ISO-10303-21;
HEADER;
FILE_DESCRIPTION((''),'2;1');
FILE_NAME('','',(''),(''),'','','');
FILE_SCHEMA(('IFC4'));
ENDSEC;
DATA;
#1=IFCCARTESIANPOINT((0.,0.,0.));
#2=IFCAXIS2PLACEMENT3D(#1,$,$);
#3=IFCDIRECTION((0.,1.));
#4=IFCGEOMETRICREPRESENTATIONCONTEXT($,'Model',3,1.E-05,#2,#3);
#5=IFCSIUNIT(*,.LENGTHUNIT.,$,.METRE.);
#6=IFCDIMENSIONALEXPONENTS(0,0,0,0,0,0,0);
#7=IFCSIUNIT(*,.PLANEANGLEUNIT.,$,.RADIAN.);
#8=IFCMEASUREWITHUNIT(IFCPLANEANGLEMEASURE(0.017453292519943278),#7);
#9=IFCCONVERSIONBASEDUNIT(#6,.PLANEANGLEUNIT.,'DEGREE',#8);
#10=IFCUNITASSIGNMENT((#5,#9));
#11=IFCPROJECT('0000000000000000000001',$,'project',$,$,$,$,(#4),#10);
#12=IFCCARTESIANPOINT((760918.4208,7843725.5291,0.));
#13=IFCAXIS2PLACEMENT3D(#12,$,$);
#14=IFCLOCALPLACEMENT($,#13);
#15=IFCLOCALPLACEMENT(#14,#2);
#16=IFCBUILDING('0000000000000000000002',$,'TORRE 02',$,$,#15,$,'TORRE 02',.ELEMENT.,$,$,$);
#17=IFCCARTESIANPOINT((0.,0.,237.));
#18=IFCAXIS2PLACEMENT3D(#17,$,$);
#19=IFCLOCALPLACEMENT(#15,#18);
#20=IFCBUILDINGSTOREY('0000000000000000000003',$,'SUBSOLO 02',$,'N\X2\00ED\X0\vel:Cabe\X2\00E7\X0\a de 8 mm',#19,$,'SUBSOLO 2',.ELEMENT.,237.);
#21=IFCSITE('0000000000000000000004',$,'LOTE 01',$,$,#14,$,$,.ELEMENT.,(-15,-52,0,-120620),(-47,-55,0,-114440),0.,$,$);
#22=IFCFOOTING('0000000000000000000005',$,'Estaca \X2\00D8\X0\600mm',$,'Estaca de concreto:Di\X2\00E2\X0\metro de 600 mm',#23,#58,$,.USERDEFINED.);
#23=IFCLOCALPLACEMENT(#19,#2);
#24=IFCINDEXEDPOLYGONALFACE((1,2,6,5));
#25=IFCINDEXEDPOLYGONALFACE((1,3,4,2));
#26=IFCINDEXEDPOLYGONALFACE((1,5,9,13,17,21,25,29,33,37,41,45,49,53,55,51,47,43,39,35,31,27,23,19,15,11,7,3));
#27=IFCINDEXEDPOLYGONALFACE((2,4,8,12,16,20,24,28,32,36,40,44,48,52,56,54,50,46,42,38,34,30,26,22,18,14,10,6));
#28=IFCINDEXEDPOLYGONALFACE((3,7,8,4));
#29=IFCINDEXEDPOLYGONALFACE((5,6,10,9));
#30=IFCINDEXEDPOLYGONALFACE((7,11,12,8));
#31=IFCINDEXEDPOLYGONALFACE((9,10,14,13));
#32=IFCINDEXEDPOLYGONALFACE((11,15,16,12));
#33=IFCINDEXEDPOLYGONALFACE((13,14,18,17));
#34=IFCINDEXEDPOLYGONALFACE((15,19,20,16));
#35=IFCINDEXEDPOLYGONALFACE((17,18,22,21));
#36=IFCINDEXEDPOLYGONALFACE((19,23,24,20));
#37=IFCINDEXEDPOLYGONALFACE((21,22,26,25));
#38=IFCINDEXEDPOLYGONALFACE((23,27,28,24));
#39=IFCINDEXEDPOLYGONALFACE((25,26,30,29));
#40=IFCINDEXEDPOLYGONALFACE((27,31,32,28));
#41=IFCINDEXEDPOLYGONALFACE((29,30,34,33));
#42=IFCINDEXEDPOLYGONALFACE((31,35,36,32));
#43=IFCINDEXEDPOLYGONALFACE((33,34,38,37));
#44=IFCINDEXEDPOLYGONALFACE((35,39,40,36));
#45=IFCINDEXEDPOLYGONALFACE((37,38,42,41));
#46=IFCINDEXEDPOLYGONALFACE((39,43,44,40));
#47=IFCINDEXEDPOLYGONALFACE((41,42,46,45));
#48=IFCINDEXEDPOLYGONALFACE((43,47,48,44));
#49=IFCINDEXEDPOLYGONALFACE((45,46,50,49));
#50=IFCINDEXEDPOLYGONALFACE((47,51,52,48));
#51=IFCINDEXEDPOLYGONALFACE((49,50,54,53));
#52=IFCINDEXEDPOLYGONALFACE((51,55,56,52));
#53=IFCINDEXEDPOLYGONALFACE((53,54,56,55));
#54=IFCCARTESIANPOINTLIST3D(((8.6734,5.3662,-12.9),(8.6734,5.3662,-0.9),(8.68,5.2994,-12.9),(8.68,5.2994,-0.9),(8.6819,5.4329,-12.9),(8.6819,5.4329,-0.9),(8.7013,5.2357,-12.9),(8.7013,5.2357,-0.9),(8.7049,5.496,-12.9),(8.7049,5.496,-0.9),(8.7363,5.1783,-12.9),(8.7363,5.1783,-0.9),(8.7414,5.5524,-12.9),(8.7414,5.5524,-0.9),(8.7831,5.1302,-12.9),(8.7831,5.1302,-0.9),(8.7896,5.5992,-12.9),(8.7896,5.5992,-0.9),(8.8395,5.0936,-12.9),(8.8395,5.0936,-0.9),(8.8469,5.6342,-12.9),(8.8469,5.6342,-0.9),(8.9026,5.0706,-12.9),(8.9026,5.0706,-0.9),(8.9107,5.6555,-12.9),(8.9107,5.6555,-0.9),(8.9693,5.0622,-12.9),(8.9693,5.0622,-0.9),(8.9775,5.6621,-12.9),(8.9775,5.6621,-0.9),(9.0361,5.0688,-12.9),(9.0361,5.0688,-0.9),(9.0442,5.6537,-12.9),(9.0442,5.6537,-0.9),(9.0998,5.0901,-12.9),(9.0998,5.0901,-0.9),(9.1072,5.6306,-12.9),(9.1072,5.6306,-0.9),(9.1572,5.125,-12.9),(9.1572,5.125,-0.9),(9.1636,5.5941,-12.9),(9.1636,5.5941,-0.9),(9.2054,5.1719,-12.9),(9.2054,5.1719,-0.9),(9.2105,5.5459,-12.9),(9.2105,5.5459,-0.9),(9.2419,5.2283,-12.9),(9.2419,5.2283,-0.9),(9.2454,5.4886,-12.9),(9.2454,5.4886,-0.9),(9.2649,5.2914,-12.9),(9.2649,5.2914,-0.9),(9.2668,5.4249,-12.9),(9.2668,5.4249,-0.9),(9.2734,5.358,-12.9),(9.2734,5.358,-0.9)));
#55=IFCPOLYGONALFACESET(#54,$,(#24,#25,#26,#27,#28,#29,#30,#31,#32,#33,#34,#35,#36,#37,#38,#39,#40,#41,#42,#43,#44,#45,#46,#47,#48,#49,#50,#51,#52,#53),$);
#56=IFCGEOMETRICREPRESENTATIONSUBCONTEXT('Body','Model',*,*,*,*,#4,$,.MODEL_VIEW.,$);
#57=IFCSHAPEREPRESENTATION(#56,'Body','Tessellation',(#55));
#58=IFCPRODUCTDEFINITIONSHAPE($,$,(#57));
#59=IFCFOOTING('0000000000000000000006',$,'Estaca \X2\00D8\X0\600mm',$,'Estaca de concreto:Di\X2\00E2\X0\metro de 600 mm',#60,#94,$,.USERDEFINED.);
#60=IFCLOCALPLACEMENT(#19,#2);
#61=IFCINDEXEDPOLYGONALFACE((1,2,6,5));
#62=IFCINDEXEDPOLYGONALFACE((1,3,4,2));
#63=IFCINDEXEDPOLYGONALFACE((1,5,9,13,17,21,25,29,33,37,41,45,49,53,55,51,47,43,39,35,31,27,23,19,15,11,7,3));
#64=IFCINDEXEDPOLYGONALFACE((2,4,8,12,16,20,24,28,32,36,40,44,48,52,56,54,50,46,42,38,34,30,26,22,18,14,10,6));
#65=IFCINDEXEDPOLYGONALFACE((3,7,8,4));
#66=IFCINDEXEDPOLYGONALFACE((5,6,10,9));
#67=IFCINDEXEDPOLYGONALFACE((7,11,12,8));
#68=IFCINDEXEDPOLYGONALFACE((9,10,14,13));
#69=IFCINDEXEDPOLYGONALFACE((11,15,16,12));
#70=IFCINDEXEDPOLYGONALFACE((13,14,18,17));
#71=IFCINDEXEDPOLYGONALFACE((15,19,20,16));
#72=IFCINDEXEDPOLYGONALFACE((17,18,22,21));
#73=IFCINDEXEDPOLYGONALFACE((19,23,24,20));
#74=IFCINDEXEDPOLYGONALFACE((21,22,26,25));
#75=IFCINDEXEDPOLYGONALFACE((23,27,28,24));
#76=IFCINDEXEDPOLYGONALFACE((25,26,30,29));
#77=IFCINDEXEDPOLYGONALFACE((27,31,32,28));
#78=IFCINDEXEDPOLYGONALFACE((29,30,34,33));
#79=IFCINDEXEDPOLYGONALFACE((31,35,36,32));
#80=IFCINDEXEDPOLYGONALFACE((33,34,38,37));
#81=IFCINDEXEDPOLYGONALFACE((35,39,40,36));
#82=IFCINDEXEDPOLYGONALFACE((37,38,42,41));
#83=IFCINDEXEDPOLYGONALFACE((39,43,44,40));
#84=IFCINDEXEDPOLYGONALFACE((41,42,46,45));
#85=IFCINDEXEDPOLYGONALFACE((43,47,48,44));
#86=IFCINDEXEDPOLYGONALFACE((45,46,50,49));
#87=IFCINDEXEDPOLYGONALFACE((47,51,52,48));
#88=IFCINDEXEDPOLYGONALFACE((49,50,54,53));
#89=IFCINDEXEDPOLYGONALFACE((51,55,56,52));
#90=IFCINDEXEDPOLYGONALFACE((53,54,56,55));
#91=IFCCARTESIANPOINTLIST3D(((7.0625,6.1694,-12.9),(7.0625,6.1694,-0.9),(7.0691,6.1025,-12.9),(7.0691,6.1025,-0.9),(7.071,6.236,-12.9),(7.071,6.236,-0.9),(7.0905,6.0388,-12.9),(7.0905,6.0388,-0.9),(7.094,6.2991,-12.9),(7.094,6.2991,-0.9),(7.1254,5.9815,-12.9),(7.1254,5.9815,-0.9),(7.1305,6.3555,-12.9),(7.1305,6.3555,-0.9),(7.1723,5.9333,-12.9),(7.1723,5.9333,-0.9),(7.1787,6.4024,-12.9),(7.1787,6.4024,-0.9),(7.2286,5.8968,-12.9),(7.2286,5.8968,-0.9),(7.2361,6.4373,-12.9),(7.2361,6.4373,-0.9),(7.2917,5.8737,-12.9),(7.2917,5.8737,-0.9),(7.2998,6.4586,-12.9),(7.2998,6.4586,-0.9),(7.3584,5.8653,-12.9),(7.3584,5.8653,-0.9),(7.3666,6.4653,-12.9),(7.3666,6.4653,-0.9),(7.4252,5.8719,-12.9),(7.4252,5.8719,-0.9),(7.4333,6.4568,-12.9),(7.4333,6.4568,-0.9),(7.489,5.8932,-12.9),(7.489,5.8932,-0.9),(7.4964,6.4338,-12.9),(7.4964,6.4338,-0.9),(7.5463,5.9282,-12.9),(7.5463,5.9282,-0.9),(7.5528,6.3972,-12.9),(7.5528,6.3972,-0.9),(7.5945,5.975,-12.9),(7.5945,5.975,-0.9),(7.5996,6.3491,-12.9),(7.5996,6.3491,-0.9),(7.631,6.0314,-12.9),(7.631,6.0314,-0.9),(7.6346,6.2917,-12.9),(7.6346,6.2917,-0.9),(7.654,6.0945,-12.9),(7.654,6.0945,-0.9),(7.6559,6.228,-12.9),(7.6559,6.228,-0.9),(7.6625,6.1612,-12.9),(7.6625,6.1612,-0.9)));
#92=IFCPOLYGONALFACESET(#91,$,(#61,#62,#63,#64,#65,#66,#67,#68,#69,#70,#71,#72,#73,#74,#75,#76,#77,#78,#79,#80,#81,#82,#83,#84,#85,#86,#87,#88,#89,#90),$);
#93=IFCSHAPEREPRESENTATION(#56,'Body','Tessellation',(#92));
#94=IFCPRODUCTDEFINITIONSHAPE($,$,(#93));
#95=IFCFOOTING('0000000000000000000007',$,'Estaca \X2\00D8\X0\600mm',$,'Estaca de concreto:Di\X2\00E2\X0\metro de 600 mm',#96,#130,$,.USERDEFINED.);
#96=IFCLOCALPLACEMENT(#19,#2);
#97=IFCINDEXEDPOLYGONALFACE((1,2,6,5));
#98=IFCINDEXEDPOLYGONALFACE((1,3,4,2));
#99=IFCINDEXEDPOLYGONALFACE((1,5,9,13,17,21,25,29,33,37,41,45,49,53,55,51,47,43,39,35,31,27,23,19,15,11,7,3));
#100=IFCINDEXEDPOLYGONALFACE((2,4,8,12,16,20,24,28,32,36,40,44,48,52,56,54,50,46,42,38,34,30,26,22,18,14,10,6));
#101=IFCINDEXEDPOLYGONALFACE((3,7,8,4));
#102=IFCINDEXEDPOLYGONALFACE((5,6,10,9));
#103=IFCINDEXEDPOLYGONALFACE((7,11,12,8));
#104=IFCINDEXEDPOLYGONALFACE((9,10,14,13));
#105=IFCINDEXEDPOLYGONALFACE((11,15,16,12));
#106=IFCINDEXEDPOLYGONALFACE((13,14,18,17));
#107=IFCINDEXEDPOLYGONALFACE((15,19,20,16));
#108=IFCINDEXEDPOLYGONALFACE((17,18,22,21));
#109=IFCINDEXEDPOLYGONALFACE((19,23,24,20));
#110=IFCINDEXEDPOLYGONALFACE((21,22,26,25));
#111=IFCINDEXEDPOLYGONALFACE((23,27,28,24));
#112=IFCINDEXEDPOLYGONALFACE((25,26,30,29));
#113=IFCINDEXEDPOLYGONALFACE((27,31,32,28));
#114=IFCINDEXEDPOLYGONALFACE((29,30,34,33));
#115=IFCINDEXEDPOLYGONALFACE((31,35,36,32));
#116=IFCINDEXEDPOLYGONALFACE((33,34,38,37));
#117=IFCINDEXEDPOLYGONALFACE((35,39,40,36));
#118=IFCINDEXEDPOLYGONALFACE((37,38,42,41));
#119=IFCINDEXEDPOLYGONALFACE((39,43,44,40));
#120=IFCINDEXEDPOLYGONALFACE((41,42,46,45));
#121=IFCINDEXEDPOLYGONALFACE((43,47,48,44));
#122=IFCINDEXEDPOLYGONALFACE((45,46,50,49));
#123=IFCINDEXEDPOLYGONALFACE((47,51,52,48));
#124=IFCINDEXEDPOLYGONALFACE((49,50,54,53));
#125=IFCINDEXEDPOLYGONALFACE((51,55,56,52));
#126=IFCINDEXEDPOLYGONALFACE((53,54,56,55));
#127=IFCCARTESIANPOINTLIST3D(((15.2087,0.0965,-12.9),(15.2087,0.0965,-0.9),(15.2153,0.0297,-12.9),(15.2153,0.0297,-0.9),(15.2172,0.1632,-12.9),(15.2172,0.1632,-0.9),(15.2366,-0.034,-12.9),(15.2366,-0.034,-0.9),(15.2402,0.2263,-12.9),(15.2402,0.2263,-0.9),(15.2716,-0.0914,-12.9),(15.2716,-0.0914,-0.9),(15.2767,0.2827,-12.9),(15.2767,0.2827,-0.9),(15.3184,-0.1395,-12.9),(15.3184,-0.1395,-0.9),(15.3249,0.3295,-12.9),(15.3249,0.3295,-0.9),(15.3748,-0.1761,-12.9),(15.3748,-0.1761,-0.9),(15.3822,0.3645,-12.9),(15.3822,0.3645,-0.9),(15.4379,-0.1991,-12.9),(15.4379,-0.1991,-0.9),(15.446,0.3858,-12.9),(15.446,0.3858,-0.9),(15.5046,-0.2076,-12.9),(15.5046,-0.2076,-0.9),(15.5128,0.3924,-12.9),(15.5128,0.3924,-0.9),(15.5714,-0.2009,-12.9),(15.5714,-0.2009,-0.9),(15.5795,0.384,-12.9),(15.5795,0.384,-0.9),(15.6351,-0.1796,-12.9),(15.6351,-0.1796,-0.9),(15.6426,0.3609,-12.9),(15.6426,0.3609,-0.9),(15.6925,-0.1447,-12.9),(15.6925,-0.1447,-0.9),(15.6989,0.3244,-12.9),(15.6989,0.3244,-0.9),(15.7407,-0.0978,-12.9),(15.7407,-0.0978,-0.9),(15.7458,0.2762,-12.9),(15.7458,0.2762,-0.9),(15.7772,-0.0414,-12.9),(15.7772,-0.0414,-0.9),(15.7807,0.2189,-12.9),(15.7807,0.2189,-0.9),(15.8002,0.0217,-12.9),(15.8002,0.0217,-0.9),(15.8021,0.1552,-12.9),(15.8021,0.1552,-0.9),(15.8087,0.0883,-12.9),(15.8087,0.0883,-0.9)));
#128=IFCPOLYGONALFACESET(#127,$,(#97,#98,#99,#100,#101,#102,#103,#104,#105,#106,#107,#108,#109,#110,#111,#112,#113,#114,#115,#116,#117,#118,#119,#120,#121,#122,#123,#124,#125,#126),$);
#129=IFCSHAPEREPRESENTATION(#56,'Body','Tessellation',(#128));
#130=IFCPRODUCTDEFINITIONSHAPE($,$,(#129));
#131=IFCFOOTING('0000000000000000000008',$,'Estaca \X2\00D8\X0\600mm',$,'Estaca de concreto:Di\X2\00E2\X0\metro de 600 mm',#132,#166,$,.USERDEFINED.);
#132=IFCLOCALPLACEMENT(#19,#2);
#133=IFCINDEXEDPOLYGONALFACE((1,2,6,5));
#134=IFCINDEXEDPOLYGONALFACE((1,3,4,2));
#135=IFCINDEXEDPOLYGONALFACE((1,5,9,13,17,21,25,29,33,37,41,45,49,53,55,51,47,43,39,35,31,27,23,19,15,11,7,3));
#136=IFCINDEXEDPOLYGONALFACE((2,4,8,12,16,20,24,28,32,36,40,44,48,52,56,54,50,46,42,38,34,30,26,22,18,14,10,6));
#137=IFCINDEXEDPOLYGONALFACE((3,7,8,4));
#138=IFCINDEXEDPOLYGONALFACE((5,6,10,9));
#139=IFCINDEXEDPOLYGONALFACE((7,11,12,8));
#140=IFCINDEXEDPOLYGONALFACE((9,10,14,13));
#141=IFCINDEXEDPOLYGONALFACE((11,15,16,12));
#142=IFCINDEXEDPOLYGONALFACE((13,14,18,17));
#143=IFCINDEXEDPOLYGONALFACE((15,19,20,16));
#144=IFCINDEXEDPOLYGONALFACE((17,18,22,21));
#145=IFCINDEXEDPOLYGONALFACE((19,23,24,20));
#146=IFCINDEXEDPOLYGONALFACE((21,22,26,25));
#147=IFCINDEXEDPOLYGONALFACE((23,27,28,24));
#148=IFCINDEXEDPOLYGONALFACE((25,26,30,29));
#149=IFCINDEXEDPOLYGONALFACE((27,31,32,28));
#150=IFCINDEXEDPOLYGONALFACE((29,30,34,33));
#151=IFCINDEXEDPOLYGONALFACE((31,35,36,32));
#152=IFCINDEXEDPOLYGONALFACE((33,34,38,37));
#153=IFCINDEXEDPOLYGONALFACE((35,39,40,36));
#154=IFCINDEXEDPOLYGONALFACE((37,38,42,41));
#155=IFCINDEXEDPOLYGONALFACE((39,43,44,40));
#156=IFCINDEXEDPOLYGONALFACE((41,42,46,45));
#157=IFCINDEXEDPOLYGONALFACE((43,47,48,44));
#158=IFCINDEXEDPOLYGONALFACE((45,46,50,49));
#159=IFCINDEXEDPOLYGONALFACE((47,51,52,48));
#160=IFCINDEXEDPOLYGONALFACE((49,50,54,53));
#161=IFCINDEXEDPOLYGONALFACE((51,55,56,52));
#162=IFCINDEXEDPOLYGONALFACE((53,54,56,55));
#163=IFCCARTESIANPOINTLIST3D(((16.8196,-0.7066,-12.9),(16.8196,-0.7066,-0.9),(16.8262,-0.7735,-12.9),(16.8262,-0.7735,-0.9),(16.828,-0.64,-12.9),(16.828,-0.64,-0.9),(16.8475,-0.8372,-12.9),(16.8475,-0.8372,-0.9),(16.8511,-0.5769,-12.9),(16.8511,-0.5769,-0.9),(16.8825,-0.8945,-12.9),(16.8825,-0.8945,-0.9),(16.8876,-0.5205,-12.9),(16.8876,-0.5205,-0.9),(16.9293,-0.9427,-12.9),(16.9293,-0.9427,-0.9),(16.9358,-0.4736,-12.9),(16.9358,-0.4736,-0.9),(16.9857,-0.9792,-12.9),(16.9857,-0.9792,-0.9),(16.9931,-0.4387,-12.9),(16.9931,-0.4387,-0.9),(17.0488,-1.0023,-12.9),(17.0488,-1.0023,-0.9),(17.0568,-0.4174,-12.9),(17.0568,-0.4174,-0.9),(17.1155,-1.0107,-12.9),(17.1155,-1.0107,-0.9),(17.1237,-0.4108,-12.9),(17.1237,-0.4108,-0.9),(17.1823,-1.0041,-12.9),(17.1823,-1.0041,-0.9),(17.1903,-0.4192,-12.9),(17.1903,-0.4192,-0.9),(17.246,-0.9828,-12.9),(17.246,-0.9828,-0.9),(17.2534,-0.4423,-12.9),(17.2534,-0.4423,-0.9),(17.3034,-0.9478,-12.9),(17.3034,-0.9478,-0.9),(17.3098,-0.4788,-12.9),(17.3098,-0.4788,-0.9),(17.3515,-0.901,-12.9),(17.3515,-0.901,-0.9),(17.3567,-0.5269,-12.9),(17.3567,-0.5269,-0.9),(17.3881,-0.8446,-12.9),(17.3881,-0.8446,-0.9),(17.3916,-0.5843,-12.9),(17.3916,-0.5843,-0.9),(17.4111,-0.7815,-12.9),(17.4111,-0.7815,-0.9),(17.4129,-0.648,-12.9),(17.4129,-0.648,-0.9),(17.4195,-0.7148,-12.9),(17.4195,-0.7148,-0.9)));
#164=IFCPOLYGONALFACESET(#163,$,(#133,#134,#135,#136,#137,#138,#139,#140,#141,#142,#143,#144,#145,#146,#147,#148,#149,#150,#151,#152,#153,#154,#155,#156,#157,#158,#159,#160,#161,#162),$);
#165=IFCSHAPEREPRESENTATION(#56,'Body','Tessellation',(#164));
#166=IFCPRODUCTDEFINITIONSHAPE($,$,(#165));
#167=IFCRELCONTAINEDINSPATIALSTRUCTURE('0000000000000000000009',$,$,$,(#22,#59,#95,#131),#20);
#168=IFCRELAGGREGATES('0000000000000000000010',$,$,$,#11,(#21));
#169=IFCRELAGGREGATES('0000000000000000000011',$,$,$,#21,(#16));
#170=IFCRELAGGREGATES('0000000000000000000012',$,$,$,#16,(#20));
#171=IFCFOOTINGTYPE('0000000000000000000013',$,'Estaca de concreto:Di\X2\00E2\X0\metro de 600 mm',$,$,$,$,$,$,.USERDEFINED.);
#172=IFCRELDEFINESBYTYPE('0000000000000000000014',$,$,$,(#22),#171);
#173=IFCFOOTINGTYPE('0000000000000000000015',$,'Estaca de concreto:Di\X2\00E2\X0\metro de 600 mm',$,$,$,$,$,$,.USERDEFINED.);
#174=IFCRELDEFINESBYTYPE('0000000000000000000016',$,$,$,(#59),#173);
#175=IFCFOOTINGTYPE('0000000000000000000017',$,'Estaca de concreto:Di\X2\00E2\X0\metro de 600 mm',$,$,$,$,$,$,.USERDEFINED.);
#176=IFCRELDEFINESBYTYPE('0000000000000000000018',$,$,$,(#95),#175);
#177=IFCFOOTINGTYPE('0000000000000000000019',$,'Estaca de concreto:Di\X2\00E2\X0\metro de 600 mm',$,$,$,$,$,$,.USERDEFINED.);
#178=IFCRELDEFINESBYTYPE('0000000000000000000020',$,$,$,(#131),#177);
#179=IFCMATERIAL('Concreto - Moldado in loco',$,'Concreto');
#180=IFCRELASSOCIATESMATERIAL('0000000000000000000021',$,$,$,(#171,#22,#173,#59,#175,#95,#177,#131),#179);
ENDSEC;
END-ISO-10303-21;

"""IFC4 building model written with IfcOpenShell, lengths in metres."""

from ifc_helpers import new_model, entity, si_unit, converted_unit, direction, frame, origin, place, context, subcontext, project, spatial, arc, indexed_curve, outline, extrude, source, transform, mapped, material, type_object, type_shapes, element, save


model = new_model("IFC4")

# Units and contexts
model_context = context("Model", 3, precision=1e-05, world=origin(), true_north=direction((0.0, 1.0)))
body_context = subcontext(model_context, "Body", "Model", "MODEL_VIEW")
ifc_project = project(units=[si_unit("LENGTHUNIT", "METRE"), converted_unit("PLANEANGLEUNIT", "DEGREE", entity("IfcPlaneAngleMeasure", 0.017453292519943278), si_unit("PLANEANGLEUNIT", "RADIAN"), dimensions=[0, 0, 0, 0, 0, 0, 0])], contexts=[model_context])

# Site, building, storey
site_placement = place(None, frame((760918.4208, 7843725.5291, 0.0)))
site = spatial("IfcSite", under=ifc_project, at=site_placement, Name="LOTE 01", CompositionType="ELEMENT", RefLatitude=(-15, -52, 0, -120620), RefLongitude=(-47, -55, 0, -114440), RefElevation=0.0)
building_placement = place(site_placement, origin())
building = spatial("IfcBuilding", under=site, at=building_placement, Name="TORRE 02", LongName="TORRE 02", CompositionType="ELEMENT")
storey_placement = place(building_placement, frame((0.0, 0.0, 237.0)))
storey = spatial("IfcBuildingStorey", under=building, at=storey_placement, Name="SUBSOLO 02", ObjectType="Nível:Cabeça de 8 mm", LongName="SUBSOLO 2", CompositionType="ELEMENT", Elevation=237.0)

# Footings
ifc_material = material(Name="Concreto - Moldado in loco", Category="Concreto")
placement = place(building_placement, frame((0.0, 0.0, 237.0)))
footing_type_1 = type_object("IfcFootingType", Name="Estaca de concreto:Diâmetro de 600 mm", PredefinedType="USERDEFINED", material=ifc_material)
shared_shape_1 = source(origin(), body_context, "Body", "SweptSolid", [
    extrude(outline(indexed_curve([(-0.3, 0.0), (0.0, -0.3), (0.3, 0.0), (0.0, 0.3)], segments=[arc(1, 2, 3), arc(3, 4, 1)], self_intersect=False)), frame((8.9734, 5.3621, -12.0), z_axis=(0.0, 0.0, 1.0), x_axis=(0.894934, -0.446198, 0.0)), (0.0, 0.0, 1.0), 12.0),
])
type_shapes(footing_type_1, [shared_shape_1])
footing_1_placement = place(placement, frame((0.0, 0.0, -0.9)))
element("IfcFooting", 1, at=footing_1_placement, inside=storey, type_object=footing_type_1, material=ifc_material, Name="Estaca Ø600mm", ObjectType="Estaca de concreto:Diâmetro de 600 mm", PredefinedType="USERDEFINED", context=body_context, shape_type="MappedRepresentation", body=[
    mapped(shared_shape_1, transform((0.0, 0.0, 0.0), scale=1.0)),
])
footing_type_2 = type_object("IfcFootingType", Name="Estaca de concreto:Diâmetro de 600 mm", PredefinedType="USERDEFINED", material=ifc_material)
shared_shape_2 = source(origin(), body_context, "Body", "SweptSolid", [
    extrude(outline(indexed_curve([(-0.3, 0.0), (0.0, -0.3), (0.3, 0.0), (0.0, 0.3)], segments=[arc(1, 2, 3), arc(3, 4, 1)], self_intersect=False)), frame((7.3625, 6.1653, -12.0), z_axis=(0.0, 0.0, 1.0), x_axis=(0.894934, -0.446198, 0.0)), (0.0, 0.0, 1.0), 12.0),
])
type_shapes(footing_type_2, [shared_shape_2])
footing_2_placement = place(placement, frame((0.0, 0.0, -0.9)))
element("IfcFooting", 2, at=footing_2_placement, inside=storey, type_object=footing_type_2, material=ifc_material, Name="Estaca Ø600mm", ObjectType="Estaca de concreto:Diâmetro de 600 mm", PredefinedType="USERDEFINED", context=body_context, shape_type="MappedRepresentation", body=[
    mapped(shared_shape_2, transform((0.0, 0.0, 0.0), scale=1.0)),
])
footing_type_3 = type_object("IfcFootingType", Name="Estaca de concreto:Diâmetro de 600 mm", PredefinedType="USERDEFINED", material=ifc_material)
shared_shape_3 = source(origin(), body_context, "Body", "SweptSolid", [
    extrude(outline(indexed_curve([(-0.3, 0.0), (0.0, -0.3), (0.3, 0.0), (0.0, 0.3)], segments=[arc(1, 2, 3), arc(3, 4, 1)], self_intersect=False)), frame((15.5087, 0.0924, -12.0), z_axis=(0.0, 0.0, 1.0), x_axis=(0.894934, -0.446198, 0.0)), (0.0, 0.0, 1.0), 12.0),
])
type_shapes(footing_type_3, [shared_shape_3])
footing_3_placement = place(placement, frame((0.0, 0.0, -0.9)))
element("IfcFooting", 3, at=footing_3_placement, inside=storey, type_object=footing_type_3, material=ifc_material, Name="Estaca Ø600mm", ObjectType="Estaca de concreto:Diâmetro de 600 mm", PredefinedType="USERDEFINED", context=body_context, shape_type="MappedRepresentation", body=[
    mapped(shared_shape_3, transform((0.0, 0.0, 0.0), scale=1.0)),
])
footing_type_4 = type_object("IfcFootingType", Name="Estaca de concreto:Diâmetro de 600 mm", PredefinedType="USERDEFINED", material=ifc_material)
shared_shape_4 = source(origin(), body_context, "Body", "SweptSolid", [
    extrude(outline(indexed_curve([(-0.3, 0.0), (0.0, -0.3), (0.3, 0.0), (0.0, 0.3)], segments=[arc(1, 2, 3), arc(3, 4, 1)], self_intersect=False)), frame((17.1196, -0.7107, -12.0), z_axis=(0.0, 0.0, 1.0), x_axis=(0.894934, -0.446198, 0.0)), (0.0, 0.0, 1.0), 12.0),
])
type_shapes(footing_type_4, [shared_shape_4])
footing_4_placement = place(placement, frame((0.0, 0.0, -0.9)))
element("IfcFooting", 4, at=footing_4_placement, inside=storey, type_object=footing_type_4, material=ifc_material, Name="Estaca Ø600mm", ObjectType="Estaca de concreto:Diâmetro de 600 mm", PredefinedType="USERDEFINED", context=body_context, shape_type="MappedRepresentation", body=[
    mapped(shared_shape_4, transform((0.0, 0.0, 0.0), scale=1.0)),
])

save(model, "model.ifc")
